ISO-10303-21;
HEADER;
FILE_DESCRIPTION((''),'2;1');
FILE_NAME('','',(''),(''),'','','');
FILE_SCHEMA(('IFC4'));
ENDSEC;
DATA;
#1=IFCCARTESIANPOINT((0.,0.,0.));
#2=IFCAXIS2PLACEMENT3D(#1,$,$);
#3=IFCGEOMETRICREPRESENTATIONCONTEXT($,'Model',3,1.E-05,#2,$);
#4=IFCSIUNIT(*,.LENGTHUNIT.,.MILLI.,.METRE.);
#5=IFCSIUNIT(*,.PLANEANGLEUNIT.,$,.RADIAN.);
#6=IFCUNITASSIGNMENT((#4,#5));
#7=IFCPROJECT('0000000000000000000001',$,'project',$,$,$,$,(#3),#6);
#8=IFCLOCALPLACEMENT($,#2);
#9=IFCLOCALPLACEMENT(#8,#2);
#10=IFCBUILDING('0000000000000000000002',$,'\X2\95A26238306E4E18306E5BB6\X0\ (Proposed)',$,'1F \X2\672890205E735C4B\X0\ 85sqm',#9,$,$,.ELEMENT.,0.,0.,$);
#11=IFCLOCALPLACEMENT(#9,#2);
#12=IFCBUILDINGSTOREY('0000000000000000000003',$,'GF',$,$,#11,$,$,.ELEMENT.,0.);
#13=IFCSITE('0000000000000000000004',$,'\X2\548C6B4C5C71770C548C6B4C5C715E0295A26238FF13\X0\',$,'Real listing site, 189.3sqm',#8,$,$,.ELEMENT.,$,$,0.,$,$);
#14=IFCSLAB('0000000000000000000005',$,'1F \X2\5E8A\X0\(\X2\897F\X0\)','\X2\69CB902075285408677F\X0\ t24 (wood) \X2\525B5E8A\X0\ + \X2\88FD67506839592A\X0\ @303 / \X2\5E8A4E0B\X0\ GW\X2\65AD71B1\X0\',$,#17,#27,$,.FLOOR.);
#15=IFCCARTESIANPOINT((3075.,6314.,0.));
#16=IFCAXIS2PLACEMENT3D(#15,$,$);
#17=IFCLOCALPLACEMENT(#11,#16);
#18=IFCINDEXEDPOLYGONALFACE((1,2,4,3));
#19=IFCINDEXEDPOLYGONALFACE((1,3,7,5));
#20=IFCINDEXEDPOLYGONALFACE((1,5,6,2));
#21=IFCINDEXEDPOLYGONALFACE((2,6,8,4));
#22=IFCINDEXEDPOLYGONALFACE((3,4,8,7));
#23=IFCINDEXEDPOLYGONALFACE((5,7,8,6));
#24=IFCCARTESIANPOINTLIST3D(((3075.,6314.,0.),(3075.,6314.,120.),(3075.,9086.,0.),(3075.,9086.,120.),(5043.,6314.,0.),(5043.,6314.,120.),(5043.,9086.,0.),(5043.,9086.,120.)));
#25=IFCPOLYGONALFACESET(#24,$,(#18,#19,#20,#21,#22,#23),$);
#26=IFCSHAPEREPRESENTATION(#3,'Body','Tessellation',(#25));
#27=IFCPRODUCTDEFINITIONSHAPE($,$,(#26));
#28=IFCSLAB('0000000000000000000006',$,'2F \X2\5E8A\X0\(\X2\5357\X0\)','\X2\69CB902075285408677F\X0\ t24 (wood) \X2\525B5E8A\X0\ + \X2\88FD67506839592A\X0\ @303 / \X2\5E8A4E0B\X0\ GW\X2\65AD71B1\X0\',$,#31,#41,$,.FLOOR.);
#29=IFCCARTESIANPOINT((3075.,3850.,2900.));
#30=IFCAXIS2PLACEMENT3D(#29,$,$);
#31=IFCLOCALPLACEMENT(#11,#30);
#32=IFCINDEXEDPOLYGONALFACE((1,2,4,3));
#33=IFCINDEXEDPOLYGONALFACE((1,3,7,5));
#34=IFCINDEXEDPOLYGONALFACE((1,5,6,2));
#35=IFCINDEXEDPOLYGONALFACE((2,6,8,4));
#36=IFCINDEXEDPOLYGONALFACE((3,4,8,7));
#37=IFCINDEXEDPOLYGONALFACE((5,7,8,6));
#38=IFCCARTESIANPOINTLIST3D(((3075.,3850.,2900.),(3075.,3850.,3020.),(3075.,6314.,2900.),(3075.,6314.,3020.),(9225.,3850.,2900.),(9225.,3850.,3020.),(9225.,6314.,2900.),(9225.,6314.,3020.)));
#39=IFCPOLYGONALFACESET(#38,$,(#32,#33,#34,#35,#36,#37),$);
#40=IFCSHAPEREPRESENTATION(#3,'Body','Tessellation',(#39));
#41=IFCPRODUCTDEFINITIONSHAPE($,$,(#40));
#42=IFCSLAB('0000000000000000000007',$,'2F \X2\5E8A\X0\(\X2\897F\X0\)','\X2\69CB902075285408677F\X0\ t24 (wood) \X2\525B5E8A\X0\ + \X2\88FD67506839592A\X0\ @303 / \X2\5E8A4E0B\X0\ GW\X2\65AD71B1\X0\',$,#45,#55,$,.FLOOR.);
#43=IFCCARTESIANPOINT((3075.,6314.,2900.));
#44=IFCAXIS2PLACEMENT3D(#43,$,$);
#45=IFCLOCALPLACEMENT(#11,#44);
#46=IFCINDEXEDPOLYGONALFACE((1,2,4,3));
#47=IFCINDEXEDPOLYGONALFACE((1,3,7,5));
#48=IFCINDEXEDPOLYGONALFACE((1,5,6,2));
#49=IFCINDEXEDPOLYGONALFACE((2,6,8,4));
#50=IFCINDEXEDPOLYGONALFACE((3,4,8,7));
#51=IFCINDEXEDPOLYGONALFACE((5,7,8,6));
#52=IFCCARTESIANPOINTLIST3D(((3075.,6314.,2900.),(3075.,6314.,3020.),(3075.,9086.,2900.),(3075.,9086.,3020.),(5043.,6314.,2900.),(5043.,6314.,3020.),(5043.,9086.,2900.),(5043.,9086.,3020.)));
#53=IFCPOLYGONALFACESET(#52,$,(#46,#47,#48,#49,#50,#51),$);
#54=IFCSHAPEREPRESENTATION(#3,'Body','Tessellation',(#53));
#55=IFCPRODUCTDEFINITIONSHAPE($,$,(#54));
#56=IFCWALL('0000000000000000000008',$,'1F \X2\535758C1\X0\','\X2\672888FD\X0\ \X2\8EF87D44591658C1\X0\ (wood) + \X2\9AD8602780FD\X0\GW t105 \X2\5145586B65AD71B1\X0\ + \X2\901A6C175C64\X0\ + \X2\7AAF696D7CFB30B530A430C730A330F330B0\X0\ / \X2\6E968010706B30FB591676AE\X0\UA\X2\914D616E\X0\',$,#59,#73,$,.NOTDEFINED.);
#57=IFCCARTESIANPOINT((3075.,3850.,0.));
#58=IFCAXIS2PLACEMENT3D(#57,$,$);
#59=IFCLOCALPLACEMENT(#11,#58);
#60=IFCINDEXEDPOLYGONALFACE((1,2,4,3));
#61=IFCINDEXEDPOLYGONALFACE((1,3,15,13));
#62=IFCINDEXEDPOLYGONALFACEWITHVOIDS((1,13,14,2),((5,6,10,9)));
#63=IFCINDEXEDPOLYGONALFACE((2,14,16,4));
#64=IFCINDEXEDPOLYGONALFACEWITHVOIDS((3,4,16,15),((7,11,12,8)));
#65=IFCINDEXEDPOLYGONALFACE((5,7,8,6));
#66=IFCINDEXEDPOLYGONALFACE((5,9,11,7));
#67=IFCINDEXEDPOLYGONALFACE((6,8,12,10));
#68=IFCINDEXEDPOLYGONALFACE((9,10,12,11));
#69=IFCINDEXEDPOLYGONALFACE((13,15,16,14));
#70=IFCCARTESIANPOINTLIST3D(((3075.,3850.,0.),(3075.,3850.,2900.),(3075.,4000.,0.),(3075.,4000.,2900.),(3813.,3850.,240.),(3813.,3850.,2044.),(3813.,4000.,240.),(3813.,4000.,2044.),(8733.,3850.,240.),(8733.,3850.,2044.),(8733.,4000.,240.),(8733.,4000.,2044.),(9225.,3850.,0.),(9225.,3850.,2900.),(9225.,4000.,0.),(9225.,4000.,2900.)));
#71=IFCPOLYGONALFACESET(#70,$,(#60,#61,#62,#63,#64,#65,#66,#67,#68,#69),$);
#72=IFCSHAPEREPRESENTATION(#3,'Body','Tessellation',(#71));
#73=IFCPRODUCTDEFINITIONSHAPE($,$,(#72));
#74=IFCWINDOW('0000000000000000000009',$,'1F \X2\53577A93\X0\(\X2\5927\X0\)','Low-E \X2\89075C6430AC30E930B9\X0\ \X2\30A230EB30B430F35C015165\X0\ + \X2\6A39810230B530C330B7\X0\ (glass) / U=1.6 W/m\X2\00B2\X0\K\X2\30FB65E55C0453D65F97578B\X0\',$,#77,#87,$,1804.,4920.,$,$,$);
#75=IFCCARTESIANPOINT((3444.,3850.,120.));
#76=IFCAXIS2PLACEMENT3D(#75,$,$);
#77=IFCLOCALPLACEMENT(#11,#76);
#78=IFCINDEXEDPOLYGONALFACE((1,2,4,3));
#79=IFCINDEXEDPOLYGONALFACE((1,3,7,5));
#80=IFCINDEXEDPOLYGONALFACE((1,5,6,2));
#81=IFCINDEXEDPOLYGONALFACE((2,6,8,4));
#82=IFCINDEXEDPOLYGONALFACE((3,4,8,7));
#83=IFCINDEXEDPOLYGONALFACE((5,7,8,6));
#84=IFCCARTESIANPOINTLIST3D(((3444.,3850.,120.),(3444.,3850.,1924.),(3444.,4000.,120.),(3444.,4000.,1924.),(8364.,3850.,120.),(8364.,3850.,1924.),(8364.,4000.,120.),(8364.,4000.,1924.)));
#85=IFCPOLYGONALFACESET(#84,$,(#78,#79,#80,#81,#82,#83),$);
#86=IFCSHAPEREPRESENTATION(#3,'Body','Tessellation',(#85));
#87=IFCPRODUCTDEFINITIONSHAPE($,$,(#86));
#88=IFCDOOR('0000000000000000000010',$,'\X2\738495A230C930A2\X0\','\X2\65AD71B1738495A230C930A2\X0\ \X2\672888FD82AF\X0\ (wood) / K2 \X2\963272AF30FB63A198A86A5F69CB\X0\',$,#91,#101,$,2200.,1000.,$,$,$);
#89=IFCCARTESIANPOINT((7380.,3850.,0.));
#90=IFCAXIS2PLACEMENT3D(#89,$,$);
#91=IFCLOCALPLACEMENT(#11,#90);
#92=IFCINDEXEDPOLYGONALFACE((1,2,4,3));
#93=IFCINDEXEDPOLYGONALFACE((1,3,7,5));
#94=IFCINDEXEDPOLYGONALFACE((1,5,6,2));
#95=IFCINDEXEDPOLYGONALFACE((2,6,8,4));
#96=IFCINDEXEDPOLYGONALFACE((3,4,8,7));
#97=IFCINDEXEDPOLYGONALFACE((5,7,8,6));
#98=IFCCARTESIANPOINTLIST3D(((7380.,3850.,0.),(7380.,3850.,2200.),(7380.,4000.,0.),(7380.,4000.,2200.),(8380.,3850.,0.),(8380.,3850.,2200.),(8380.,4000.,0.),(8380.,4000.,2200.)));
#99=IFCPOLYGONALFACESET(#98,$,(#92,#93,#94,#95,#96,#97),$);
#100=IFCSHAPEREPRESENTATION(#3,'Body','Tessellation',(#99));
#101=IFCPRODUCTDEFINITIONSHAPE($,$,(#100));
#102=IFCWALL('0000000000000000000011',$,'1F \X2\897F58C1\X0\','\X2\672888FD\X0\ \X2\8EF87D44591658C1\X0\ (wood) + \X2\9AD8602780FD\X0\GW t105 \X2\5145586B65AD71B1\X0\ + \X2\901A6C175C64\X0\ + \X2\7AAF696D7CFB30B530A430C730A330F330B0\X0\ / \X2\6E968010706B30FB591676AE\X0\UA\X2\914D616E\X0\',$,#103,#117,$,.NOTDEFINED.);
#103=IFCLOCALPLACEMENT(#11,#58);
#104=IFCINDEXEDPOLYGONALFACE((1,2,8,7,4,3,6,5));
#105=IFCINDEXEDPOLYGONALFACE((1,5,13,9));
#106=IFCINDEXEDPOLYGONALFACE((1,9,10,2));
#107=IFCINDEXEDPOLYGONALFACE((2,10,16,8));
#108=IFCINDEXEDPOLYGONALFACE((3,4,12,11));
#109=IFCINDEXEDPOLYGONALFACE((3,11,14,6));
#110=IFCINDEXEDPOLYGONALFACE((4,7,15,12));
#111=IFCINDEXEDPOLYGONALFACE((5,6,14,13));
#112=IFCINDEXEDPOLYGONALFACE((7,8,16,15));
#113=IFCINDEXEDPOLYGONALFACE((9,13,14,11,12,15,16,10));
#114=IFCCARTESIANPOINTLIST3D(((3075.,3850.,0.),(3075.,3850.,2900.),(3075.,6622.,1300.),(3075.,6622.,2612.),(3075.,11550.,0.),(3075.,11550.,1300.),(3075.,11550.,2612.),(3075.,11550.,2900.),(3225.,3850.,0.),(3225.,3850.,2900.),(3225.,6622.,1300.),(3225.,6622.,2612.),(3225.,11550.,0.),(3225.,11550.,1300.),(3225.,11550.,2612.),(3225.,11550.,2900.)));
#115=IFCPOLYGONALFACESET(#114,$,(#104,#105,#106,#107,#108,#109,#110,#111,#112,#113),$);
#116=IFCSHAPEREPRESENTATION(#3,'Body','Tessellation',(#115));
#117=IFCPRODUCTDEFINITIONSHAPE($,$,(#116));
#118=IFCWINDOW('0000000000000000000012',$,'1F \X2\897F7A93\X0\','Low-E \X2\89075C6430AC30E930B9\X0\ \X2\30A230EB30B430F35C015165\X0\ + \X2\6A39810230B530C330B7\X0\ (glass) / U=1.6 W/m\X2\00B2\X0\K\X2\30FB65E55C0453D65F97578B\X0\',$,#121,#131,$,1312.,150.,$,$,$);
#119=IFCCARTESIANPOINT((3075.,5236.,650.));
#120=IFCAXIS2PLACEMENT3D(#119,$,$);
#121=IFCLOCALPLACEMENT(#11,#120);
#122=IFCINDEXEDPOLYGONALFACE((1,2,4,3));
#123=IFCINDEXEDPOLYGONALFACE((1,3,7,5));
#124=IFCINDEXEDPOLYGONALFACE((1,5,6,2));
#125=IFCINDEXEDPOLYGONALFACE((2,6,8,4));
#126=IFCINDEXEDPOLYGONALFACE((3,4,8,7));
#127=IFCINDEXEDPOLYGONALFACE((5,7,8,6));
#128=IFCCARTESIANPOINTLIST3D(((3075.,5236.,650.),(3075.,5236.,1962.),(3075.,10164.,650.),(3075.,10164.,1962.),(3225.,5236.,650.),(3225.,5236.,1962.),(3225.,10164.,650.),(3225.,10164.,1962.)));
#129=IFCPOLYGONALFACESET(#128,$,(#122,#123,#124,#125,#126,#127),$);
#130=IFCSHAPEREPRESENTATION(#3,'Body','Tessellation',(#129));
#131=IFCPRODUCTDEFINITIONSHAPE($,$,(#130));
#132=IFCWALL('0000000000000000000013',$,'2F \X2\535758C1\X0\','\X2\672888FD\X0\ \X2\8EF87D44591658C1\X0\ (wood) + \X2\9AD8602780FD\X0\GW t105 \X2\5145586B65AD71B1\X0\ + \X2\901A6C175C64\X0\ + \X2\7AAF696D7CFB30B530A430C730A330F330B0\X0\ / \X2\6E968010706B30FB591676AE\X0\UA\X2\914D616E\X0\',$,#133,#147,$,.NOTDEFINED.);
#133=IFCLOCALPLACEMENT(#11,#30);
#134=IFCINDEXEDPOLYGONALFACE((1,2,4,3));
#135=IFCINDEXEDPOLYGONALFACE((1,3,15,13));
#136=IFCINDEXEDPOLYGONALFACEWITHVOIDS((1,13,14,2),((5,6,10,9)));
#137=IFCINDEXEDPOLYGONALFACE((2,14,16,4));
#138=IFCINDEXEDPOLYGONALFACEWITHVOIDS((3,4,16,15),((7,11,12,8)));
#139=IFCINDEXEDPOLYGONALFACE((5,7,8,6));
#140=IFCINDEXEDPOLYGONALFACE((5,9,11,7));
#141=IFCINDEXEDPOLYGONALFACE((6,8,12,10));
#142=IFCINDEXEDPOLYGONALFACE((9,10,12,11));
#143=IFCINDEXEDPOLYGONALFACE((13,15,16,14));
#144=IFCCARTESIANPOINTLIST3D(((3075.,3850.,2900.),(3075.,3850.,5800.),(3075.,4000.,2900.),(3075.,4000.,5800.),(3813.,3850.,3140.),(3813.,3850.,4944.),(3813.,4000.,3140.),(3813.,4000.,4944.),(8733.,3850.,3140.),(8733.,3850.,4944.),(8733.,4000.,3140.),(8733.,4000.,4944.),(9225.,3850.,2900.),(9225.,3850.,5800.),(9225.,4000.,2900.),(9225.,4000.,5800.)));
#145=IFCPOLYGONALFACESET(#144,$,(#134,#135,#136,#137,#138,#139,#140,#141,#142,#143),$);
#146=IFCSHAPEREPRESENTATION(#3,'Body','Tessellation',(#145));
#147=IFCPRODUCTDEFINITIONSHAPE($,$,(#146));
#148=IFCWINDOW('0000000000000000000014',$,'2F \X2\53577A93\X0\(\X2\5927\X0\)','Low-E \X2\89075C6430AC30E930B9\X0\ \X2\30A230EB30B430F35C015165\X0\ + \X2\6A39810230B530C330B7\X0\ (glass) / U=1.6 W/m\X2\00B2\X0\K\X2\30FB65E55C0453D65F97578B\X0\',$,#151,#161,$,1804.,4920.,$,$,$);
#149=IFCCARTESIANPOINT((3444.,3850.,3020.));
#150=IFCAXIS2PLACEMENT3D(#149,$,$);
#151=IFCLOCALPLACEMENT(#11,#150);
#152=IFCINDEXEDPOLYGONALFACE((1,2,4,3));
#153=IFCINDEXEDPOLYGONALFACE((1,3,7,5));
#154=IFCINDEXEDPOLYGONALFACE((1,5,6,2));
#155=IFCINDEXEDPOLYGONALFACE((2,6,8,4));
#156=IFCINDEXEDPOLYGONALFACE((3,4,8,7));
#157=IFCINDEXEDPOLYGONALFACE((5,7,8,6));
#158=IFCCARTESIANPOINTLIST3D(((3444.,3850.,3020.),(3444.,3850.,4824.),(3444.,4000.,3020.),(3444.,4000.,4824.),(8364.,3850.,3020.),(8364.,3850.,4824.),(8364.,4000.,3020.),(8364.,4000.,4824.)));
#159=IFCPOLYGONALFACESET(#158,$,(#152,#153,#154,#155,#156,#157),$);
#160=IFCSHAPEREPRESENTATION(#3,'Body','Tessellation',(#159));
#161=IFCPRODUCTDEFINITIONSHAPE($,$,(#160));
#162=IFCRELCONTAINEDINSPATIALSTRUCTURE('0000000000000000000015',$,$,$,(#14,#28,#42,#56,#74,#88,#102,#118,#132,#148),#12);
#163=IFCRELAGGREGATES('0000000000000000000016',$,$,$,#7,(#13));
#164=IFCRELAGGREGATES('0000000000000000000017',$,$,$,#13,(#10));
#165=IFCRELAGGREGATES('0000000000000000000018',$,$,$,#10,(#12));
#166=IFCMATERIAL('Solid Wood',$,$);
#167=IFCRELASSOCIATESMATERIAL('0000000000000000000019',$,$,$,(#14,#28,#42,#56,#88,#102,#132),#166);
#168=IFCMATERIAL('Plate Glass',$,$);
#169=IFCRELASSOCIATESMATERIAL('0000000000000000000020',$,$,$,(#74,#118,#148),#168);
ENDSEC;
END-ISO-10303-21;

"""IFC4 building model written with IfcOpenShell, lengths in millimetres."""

from ifc_helpers import new_model, si_unit, frame, frame_2d, origin, place, context, project, spatial, rectangle, extrude, material, element, fill, save


model = new_model("IFC4")

# Units and contexts
model_context = context("Model", 3, precision=1e-05, world=origin())
ifc_project = project(units=[si_unit("LENGTHUNIT", "METRE", prefix="MILLI"), si_unit("PLANEANGLEUNIT", "RADIAN")], contexts=[model_context])

# Site, building, storey
site_placement = place(None, origin())
site = spatial("IfcSite", under=ifc_project, at=site_placement, Name="和歌山県和歌山市関戸３", ObjectType="Real listing site, 189.3sqm", CompositionType="ELEMENT", RefElevation=0.0)
building_placement = place(site_placement, origin())
building = spatial("IfcBuilding", under=site, at=building_placement, Name="関戸の丘の家 (Proposed)", ObjectType="1F 木造平屋 85sqm", CompositionType="ELEMENT", ElevationOfRefHeight=0.0, ElevationOfTerrain=0.0)
storey_placement = place(building_placement, origin())
storey = spatial("IfcBuildingStorey", under=building, at=storey_placement, Name="GF", CompositionType="ELEMENT", Elevation=0.0)

# Slabs
ifc_material_1 = material(Name="Solid Wood")
slab_1_placement = place(storey_placement, frame((3075.0, 6314.0, 0.0)))
element("IfcSlab", 1, at=slab_1_placement, inside=storey, material=ifc_material_1, Name="1F 床(西)", Description="構造用合板 t24 (wood) 剛床 + 製材根太 @303 / 床下 GW断熱", PredefinedType="FLOOR", context=model_context, shape_type="SweptSolid", body=[
    extrude(rectangle(XDim=1968.0, YDim=2772.0, at=frame_2d((984.0, 1386.0))), frame((3075.0, 6314.0, 0.0)), (0.0, 0.0, 1.0), 120.0),
])
slab_2_placement = place(storey_placement, frame((3075.0, 3850.0, 2900.0)))
element("IfcSlab", 2, at=slab_2_placement, inside=storey, material=ifc_material_1, Name="2F 床(南)", Description="構造用合板 t24 (wood) 剛床 + 製材根太 @303 / 床下 GW断熱", PredefinedType="FLOOR", context=model_context, shape_type="SweptSolid", body=[
    extrude(rectangle(XDim=6150.0, YDim=2464.0, at=frame_2d((3075.0, 1232.0))), frame((3075.0, 3850.0, 2900.0)), (0.0, 0.0, 1.0), 120.0),
])
slab_3_placement = place(storey_placement, frame((3075.0, 6314.0, 2900.0)))
element("IfcSlab", 3, at=slab_3_placement, inside=storey, material=ifc_material_1, Name="2F 床(西)", Description="構造用合板 t24 (wood) 剛床 + 製材根太 @303 / 床下 GW断熱", PredefinedType="FLOOR", context=model_context, shape_type="SweptSolid", body=[
    extrude(rectangle(XDim=1968.0, YDim=2772.0, at=frame_2d((984.0, 1386.0))), frame((3075.0, 6314.0, 2900.0)), (0.0, 0.0, 1.0), 120.0),
])

# Wall, openings, window, door
wall_1_placement = place(storey_placement, frame((3075.0, 3850.0, 0.0)))
wall_1 = element("IfcWall", 4, at=wall_1_placement, inside=storey, material=ifc_material_1, Name="1F 南壁", Description="木製 軸組外壁 (wood) + 高性能GW t105 充填断熱 + 通気層 + 窯業系サイディング / 準耐火・外皮UA配慮", PredefinedType="NOTDEFINED", context=model_context, shape_type="SweptSolid", body=[
    extrude(rectangle(XDim=6150.0, YDim=150.0, at=frame_2d((3075.0, 75.0))), frame((3075.0, 3850.0, 0.0)), (0.0, 0.0, 1.0), 2900.0),
])
opening_1_placement = place(storey_placement, frame((3444.0, 3850.0, 120.0)))
opening_1 = element("IfcOpeningElement", 5, at=opening_1_placement, cuts=wall_1, PredefinedType="NOTDEFINED", context=model_context, shape_type="SweptSolid", body=[
    extrude(rectangle(XDim=4920.0, YDim=150.0, at=frame_2d((2460.0, 75.0))), frame((3444.0, 3850.0, 120.0)), (0.0, 0.0, 1.0), 1804.0),
])
opening_2_placement = place(storey_placement, frame((7380.0, 3850.0, 0.0)))
opening_2 = element("IfcOpeningElement", 6, at=opening_2_placement, cuts=wall_1, PredefinedType="NOTDEFINED", context=model_context, shape_type="SweptSolid", body=[
    extrude(rectangle(XDim=1000.0, YDim=150.0, at=frame_2d((500.0, 75.0))), frame((7380.0, 3850.0, 0.0)), (0.0, 0.0, 1.0), 2200.0),
])
ifc_material_2 = material(Name="Plate Glass")
window_1_placement = place(storey_placement, frame((3444.0, 3850.0, 120.0)))
window_1 = element("IfcWindow", 7, at=window_1_placement, inside=storey, material=ifc_material_2, Name="1F 南窓(大)", Description="Low-E 複層ガラス アルゴン封入 + 樹脂サッシ (glass) / U=1.6 W/m²K・日射取得型", OverallHeight=1804.0, OverallWidth=4920.0, context=model_context, shape_type="SweptSolid", body=[
    extrude(rectangle(XDim=4920.0, YDim=150.0, at=frame_2d((2460.0, 75.0))), frame((3444.0, 3850.0, 120.0)), (0.0, 0.0, 1.0), 1804.0),
])
fill(opening_1, window_1)
door_placement = place(storey_placement, frame((7380.0, 3850.0, 0.0)))
door = element("IfcDoor", 8, at=door_placement, inside=storey, material=ifc_material_1, Name="玄関ドア", Description="断熱玄関ドア 木製芯 (wood) / K2 防犯・採風機構", OverallHeight=2200.0, OverallWidth=1000.0, context=model_context, shape_type="SweptSolid", body=[
    extrude(rectangle(XDim=1000.0, YDim=150.0, at=frame_2d((500.0, 75.0))), frame((7380.0, 3850.0, 0.0)), (0.0, 0.0, 1.0), 2200.0),
])
fill(opening_2, door)

# Walls, openings, windows
wall_2_placement = place(storey_placement, frame((3075.0, 3850.0, 0.0)))
wall_2 = element("IfcWall", 9, at=wall_2_placement, inside=storey, material=ifc_material_1, Name="1F 西壁", Description="木製 軸組外壁 (wood) + 高性能GW t105 充填断熱 + 通気層 + 窯業系サイディング / 準耐火・外皮UA配慮", PredefinedType="NOTDEFINED", context=model_context, shape_type="SweptSolid", body=[
    extrude(rectangle(XDim=150.0, YDim=7700.0, at=frame_2d((75.0, 3850.0))), frame((3075.0, 3850.0, 0.0)), (0.0, 0.0, 1.0), 2900.0),
])
opening_3_placement = place(storey_placement, frame((3075.0, 5236.0, 650.0)))
opening_3 = element("IfcOpeningElement", 10, at=opening_3_placement, cuts=wall_2, PredefinedType="NOTDEFINED", context=model_context, shape_type="SweptSolid", body=[
    extrude(rectangle(XDim=150.0, YDim=4928.0, at=frame_2d((75.0, 2464.0))), frame((3075.0, 5236.0, 650.0)), (0.0, 0.0, 1.0), 1312.0),
])
window_2_placement = place(storey_placement, frame((3075.0, 5236.0, 650.0)))
window_2 = element("IfcWindow", 11, at=window_2_placement, inside=storey, material=ifc_material_2, Name="1F 西窓", Description="Low-E 複層ガラス アルゴン封入 + 樹脂サッシ (glass) / U=1.6 W/m²K・日射取得型", OverallHeight=1312.0, OverallWidth=150.0, context=model_context, shape_type="SweptSolid", body=[
    extrude(rectangle(XDim=150.0, YDim=4928.0, at=frame_2d((75.0, 2464.0))), frame((3075.0, 5236.0, 650.0)), (0.0, 0.0, 1.0), 1312.0),
])
fill(opening_3, window_2)
wall_3_placement = place(storey_placement, frame((3075.0, 3850.0, 2900.0)))
wall_3 = element("IfcWall", 12, at=wall_3_placement, inside=storey, material=ifc_material_1, Name="2F 南壁", Description="木製 軸組外壁 (wood) + 高性能GW t105 充填断熱 + 通気層 + 窯業系サイディング / 準耐火・外皮UA配慮", PredefinedType="NOTDEFINED", context=model_context, shape_type="SweptSolid", body=[
    extrude(rectangle(XDim=6150.0, YDim=150.0, at=frame_2d((3075.0, 75.0))), frame((3075.0, 3850.0, 2900.0)), (0.0, 0.0, 1.0), 2900.0),
])
opening_4_placement = place(storey_placement, frame((3444.0, 3850.0, 3020.0)))
opening_4 = element("IfcOpeningElement", 13, at=opening_4_placement, cuts=wall_3, PredefinedType="NOTDEFINED", context=model_context, shape_type="SweptSolid", body=[
    extrude(rectangle(XDim=4920.0, YDim=150.0, at=frame_2d((2460.0, 75.0))), frame((3444.0, 3850.0, 3020.0)), (0.0, 0.0, 1.0), 1804.0),
])
window_3_placement = place(storey_placement, frame((3444.0, 3850.0, 3020.0)))
window_3 = element("IfcWindow", 14, at=window_3_placement, inside=storey, material=ifc_material_2, Name="2F 南窓(大)", Description="Low-E 複層ガラス アルゴン封入 + 樹脂サッシ (glass) / U=1.6 W/m²K・日射取得型", OverallHeight=1804.0, OverallWidth=4920.0, context=model_context, shape_type="SweptSolid", body=[
    extrude(rectangle(XDim=4920.0, YDim=150.0, at=frame_2d((2460.0, 75.0))), frame((3444.0, 3850.0, 3020.0)), (0.0, 0.0, 1.0), 1804.0),
])
fill(opening_4, window_3)

save(model, "model.ifc")
